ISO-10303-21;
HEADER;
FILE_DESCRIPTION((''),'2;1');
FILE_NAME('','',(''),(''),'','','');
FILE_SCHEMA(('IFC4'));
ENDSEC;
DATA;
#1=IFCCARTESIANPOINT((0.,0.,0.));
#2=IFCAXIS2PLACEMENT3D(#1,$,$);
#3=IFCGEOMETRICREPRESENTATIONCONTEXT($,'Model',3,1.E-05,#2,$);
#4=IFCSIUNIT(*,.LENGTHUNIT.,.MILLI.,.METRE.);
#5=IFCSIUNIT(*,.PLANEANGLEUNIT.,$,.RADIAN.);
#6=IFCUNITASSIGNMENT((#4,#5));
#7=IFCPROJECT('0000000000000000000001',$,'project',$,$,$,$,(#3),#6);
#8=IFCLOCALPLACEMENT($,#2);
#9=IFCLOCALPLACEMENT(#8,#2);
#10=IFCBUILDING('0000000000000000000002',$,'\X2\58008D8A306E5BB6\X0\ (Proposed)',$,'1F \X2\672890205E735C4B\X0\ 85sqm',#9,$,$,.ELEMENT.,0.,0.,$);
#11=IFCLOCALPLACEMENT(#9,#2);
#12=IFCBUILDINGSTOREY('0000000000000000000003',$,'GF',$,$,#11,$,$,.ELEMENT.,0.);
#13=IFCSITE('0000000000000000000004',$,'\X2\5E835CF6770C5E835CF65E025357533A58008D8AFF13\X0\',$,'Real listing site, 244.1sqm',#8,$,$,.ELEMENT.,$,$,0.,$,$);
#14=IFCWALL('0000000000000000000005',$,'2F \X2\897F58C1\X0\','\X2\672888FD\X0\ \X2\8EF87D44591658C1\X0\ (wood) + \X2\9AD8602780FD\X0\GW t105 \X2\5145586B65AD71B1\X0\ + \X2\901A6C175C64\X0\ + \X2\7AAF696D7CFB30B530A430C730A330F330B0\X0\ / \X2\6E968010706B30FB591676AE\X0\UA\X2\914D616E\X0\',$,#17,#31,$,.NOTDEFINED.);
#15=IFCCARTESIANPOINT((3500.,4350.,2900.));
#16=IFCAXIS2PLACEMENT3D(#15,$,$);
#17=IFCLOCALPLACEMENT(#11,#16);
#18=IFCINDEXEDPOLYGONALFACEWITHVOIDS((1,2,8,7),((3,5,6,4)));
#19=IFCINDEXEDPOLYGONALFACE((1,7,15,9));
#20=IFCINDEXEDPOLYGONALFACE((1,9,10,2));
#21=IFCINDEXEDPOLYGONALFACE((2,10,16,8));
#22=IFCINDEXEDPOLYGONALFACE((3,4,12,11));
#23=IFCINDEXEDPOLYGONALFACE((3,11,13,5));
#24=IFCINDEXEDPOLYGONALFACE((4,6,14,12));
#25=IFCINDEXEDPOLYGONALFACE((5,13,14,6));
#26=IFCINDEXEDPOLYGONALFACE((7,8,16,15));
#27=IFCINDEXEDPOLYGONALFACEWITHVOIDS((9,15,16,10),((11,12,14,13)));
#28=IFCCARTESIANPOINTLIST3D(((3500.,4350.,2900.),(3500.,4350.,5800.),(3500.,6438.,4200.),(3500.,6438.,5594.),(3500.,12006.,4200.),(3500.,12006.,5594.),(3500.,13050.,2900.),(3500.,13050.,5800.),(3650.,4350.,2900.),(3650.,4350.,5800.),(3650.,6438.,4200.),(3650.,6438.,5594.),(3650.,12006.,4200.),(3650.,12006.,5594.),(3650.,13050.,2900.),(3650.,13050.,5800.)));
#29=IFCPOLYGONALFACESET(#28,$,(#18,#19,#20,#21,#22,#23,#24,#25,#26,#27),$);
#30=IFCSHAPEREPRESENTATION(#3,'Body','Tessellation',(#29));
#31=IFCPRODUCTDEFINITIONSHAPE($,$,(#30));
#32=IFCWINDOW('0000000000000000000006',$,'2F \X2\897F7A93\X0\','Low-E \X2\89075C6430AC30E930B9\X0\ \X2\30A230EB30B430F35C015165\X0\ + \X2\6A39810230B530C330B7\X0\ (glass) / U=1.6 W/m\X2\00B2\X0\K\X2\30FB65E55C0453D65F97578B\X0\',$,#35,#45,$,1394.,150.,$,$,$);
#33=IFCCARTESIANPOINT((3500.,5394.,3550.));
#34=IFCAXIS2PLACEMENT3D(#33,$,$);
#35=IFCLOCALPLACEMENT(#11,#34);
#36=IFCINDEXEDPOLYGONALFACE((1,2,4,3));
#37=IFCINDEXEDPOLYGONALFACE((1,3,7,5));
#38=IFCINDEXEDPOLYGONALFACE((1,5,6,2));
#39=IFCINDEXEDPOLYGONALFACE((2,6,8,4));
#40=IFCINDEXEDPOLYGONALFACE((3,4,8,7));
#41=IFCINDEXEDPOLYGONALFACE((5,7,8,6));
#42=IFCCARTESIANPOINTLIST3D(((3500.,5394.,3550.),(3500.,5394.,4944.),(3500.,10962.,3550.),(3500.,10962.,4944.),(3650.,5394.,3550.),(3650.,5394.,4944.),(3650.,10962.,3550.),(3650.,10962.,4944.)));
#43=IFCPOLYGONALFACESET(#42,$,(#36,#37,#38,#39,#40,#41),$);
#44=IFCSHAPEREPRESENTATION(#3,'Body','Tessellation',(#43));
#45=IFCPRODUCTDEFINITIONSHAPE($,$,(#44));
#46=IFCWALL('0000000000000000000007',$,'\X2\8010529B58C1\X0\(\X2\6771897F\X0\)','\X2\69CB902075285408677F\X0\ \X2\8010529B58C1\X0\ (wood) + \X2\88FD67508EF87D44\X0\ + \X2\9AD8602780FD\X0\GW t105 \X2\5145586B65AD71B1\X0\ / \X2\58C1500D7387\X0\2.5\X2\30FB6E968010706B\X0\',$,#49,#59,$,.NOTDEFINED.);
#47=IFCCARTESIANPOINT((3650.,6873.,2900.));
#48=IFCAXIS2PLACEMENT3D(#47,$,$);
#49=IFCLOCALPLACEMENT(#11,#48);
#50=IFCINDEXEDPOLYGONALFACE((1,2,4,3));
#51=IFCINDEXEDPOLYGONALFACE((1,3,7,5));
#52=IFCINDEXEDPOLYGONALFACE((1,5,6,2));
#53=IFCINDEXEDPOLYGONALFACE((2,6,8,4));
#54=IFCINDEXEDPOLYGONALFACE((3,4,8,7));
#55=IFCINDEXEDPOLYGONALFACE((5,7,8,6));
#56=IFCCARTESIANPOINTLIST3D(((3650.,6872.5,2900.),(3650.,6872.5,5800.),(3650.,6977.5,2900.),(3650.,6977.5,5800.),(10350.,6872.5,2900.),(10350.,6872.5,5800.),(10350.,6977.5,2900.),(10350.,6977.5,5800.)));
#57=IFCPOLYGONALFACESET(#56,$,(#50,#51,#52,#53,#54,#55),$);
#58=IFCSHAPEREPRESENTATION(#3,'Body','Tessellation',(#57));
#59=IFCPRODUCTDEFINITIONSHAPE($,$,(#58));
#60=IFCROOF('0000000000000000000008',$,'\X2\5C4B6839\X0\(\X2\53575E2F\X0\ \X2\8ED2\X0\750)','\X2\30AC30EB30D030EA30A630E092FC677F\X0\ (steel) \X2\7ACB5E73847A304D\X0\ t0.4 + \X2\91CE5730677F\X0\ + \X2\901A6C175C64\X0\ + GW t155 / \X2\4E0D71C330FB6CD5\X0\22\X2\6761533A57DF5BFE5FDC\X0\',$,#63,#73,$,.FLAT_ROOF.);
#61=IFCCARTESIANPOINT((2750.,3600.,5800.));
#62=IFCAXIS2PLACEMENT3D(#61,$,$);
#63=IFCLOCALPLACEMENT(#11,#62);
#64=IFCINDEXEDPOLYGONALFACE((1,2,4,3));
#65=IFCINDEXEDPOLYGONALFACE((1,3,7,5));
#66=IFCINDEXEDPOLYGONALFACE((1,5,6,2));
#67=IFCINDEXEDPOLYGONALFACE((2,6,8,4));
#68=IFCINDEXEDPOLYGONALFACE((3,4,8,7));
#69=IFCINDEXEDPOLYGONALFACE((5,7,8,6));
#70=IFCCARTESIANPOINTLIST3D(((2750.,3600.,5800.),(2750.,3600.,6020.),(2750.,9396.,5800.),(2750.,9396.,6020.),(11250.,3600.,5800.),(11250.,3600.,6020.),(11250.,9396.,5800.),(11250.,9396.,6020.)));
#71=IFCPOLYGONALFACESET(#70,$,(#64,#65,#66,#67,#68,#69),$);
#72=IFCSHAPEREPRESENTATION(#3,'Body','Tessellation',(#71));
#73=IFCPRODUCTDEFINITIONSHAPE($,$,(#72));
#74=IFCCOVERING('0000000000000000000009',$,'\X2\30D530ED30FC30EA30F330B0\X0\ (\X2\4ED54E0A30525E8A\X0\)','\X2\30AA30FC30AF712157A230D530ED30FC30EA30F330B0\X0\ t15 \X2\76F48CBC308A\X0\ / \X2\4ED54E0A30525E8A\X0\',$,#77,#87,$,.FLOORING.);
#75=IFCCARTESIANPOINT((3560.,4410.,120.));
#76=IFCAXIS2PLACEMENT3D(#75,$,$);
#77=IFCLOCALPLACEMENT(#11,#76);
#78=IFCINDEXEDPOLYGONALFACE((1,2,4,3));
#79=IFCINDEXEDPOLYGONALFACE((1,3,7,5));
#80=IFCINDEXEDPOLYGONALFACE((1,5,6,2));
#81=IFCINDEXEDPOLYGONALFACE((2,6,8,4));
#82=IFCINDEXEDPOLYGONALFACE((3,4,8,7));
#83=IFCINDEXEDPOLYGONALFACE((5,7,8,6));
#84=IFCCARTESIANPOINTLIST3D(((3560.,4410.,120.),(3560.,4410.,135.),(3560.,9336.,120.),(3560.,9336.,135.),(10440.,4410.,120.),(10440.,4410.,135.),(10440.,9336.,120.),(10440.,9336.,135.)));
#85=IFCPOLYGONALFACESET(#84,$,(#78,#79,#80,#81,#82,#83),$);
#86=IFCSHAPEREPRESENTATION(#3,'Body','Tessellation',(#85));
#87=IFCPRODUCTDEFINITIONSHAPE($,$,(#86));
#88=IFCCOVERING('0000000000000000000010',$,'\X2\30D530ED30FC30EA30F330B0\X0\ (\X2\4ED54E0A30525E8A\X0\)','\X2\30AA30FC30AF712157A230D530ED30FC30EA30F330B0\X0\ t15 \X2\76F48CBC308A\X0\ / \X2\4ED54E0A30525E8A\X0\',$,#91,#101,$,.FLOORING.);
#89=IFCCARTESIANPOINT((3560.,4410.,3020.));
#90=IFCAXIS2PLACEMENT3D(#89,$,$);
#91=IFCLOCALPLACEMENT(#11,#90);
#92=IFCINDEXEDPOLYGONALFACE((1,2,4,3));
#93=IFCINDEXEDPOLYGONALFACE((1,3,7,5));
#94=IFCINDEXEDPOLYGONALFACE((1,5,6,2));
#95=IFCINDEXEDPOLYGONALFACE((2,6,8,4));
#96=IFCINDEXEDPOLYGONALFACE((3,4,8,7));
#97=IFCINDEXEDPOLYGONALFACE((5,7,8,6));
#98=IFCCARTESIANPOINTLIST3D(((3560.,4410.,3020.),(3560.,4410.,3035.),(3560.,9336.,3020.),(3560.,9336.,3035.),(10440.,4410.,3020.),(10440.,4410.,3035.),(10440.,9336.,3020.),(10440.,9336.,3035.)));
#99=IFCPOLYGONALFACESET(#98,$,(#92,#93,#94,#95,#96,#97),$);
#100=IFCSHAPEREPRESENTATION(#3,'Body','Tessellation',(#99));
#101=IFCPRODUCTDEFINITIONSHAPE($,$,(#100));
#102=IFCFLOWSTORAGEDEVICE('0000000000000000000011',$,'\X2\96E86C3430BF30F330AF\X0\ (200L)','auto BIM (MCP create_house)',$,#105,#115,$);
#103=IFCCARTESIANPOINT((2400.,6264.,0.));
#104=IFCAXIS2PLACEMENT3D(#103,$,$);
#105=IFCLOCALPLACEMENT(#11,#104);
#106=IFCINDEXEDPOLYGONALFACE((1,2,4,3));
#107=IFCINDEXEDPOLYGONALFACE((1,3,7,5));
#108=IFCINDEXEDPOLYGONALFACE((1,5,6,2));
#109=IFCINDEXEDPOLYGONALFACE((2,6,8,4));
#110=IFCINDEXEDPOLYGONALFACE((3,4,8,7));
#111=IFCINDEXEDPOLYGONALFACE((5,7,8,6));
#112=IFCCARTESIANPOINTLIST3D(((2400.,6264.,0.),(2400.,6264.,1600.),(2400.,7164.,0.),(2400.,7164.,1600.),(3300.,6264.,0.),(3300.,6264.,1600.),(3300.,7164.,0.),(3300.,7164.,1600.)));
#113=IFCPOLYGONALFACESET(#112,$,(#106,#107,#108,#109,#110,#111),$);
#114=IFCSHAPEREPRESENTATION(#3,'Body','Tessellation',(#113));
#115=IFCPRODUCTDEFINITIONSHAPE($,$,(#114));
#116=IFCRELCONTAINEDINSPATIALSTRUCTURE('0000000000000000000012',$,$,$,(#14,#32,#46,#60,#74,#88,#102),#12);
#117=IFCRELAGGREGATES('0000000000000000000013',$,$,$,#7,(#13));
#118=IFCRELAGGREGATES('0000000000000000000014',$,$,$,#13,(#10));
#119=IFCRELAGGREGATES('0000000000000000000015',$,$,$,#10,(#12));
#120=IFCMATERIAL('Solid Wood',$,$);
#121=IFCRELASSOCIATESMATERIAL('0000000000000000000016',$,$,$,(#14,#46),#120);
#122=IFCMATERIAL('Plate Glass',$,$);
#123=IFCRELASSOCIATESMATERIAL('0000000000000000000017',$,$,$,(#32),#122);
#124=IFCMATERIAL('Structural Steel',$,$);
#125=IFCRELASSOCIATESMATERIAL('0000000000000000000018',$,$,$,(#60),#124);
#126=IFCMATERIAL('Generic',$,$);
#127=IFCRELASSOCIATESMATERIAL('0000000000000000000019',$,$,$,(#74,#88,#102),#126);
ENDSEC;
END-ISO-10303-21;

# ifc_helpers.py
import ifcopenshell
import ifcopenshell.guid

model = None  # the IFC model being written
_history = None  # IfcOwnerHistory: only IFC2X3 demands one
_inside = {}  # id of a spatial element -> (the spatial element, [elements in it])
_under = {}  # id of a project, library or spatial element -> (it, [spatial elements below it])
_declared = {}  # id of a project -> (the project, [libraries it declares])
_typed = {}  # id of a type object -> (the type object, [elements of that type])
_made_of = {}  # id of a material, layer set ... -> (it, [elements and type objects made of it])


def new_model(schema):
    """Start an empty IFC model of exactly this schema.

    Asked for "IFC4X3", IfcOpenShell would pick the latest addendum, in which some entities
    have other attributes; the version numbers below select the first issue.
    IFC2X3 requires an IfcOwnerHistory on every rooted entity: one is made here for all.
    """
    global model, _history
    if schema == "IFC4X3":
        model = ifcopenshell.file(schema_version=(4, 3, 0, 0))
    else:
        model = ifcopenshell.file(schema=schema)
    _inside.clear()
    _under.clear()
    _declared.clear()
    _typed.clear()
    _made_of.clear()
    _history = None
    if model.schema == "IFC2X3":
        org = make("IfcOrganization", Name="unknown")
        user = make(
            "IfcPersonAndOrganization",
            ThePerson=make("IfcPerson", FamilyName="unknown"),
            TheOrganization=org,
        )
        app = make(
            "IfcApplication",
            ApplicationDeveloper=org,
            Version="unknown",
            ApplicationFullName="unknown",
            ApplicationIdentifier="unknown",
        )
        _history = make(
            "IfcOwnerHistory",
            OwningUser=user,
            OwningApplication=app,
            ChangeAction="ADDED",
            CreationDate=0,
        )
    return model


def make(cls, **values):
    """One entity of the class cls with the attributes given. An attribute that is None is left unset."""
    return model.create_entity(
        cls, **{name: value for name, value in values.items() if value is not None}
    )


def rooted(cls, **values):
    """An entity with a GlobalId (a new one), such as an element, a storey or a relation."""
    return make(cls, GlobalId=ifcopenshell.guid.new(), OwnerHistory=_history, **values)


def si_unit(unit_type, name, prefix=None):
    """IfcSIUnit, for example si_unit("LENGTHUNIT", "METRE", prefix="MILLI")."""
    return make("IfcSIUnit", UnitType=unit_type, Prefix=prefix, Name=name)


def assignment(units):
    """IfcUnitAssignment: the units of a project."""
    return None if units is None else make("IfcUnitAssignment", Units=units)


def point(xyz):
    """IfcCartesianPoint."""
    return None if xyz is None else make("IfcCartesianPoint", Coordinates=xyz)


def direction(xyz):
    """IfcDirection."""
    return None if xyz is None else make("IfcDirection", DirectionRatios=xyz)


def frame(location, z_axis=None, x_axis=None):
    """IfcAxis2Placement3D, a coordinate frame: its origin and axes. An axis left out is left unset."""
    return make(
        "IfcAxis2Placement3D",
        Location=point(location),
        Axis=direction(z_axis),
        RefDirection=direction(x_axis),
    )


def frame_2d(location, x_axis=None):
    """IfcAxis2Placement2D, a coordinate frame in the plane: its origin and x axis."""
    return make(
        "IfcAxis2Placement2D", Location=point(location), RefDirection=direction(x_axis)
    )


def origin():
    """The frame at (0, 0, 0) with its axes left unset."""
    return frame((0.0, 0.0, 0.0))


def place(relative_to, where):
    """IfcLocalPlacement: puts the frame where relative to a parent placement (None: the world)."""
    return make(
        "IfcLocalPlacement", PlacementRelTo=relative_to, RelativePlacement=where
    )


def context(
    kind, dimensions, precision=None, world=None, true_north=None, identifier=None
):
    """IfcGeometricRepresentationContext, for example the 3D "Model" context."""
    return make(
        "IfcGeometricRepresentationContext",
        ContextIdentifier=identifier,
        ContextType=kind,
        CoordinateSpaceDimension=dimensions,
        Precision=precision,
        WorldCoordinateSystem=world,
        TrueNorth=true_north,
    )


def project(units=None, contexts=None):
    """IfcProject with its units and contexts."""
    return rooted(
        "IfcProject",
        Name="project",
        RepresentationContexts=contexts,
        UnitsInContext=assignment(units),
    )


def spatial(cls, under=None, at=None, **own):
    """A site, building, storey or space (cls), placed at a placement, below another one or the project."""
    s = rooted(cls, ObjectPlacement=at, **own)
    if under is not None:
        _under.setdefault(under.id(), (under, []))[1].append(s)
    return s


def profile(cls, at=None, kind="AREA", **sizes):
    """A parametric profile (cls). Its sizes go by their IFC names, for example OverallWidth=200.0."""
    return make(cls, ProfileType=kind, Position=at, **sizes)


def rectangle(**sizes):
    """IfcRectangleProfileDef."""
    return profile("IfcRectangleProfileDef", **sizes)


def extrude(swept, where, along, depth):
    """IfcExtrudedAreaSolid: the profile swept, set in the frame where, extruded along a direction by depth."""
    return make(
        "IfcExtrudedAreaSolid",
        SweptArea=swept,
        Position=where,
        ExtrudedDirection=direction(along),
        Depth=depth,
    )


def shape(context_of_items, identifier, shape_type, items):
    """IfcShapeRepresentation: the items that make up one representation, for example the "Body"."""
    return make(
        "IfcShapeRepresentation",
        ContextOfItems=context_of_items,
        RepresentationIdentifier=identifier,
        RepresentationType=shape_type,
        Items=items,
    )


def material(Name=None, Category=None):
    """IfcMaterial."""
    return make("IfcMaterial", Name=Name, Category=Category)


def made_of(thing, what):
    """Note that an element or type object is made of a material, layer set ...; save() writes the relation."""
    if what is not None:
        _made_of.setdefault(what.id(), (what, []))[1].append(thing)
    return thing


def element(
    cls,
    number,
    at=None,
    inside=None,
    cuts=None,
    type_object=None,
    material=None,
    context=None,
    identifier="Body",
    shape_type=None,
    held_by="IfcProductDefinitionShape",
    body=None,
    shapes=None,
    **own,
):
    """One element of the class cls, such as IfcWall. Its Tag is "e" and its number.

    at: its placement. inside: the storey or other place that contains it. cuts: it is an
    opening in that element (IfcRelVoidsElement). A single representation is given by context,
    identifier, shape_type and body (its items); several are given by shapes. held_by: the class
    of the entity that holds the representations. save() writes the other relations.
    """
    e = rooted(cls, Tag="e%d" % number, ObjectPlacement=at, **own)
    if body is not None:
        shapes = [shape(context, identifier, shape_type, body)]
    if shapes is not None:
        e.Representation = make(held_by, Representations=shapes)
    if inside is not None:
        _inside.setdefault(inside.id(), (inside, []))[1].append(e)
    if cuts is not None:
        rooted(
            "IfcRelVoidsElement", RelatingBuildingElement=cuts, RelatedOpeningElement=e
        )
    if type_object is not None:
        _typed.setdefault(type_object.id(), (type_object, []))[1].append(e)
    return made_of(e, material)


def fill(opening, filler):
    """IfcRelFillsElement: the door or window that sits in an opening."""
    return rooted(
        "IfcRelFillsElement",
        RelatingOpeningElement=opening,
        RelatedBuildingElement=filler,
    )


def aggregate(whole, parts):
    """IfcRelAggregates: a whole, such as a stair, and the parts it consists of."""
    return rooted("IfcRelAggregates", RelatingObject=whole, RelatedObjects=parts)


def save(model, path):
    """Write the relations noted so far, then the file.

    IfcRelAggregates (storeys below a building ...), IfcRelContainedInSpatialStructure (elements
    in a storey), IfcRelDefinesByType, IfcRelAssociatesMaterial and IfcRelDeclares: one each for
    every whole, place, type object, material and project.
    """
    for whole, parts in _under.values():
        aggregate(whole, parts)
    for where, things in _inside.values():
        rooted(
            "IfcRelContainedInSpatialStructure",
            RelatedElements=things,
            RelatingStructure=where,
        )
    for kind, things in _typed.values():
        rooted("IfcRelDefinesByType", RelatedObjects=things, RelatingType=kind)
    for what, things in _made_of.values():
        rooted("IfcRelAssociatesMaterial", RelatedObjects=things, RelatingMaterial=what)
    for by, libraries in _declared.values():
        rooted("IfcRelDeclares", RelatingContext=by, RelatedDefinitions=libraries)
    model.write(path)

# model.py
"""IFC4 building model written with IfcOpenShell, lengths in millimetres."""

from ifc_helpers import new_model, si_unit, frame, frame_2d, origin, place, context, project, spatial, rectangle, extrude, material, element, fill, save


model = new_model("IFC4")

# Units and contexts
model_context = context("Model", 3, precision=1e-05, world=origin())
ifc_project = project(units=[si_unit("LENGTHUNIT", "METRE", prefix="MILLI"), si_unit("PLANEANGLEUNIT", "RADIAN")], contexts=[model_context])

# Site, building, storey
site_placement = place(None, origin())
site = spatial("IfcSite", under=ifc_project, at=site_placement, Name="広島県広島市南区堀越３", ObjectType="Real listing site, 244.1sqm", CompositionType="ELEMENT", RefElevation=0.0)
building_placement = place(site_placement, origin())
building = spatial("IfcBuilding", under=site, at=building_placement, Name="堀越の家 (Proposed)", ObjectType="1F 木造平屋 85sqm", CompositionType="ELEMENT", ElevationOfRefHeight=0.0, ElevationOfTerrain=0.0)
storey_placement = place(building_placement, origin())
storey = spatial("IfcBuildingStorey", under=building, at=storey_placement, Name="GF", CompositionType="ELEMENT", Elevation=0.0)

# Shared definitions
ifc_material_1 = material(Name="Solid Wood")
ifc_material_2 = material(Name="Generic")

# Shared definitions
ifc_material_3 = material(Name="Plate Glass")

# Wall, opening, window
wall_1_placement = place(storey_placement, frame((3500.0, 4350.0, 2900.0)))
wall_1 = element("IfcWall", 1, at=wall_1_placement, inside=storey, material=ifc_material_1, Name="2F 西壁", Description="木製 軸組外壁 (wood) + 高性能GW t105 充填断熱 + 通気層 + 窯業系サイディング / 準耐火・外皮UA配慮", PredefinedType="NOTDEFINED", context=model_context, shape_type="SweptSolid", body=[
    extrude(rectangle(XDim=150.0, YDim=8700.0, at=frame_2d((75.0, 4350.0))), frame((3500.0, 4350.0, 2900.0)), (0.0, 0.0, 1.0), 2900.0),
])
opening_1_placement = place(storey_placement, frame((3500.0, 5394.0, 3550.0)))
opening_1 = element("IfcOpeningElement", 2, at=opening_1_placement, cuts=wall_1, PredefinedType="NOTDEFINED", context=model_context, shape_type="SweptSolid", body=[
    extrude(rectangle(XDim=150.0, YDim=5568.0, at=frame_2d((75.0, 2784.0))), frame((3500.0, 5394.0, 3550.0)), (0.0, 0.0, 1.0), 1394.0),
])
window_1_placement = place(storey_placement, frame((3500.0, 5394.0, 3550.0)))
window_1 = element("IfcWindow", 3, at=window_1_placement, inside=storey, material=ifc_material_3, Name="2F 西窓", Description="Low-E 複層ガラス アルゴン封入 + 樹脂サッシ (glass) / U=1.6 W/m²K・日射取得型", OverallHeight=1394.0, OverallWidth=150.0, context=model_context, shape_type="SweptSolid", body=[
    extrude(rectangle(XDim=150.0, YDim=5568.0, at=frame_2d((75.0, 2784.0))), frame((3500.0, 5394.0, 3550.0)), (0.0, 0.0, 1.0), 1394.0),
])
fill(opening_1, window_1)

# Wall
wall_2_placement = place(storey_placement, frame((3650.0, 6873.0, 2900.0)))
element("IfcWall", 4, at=wall_2_placement, inside=storey, material=ifc_material_1, Name="耐力壁(東西)", Description="構造用合板 耐力壁 (wood) + 製材軸組 + 高性能GW t105 充填断熱 / 壁倍率2.5・準耐火", PredefinedType="NOTDEFINED", context=model_context, shape_type="SweptSolid", body=[
    extrude(rectangle(XDim=6700.0, YDim=105.0, at=frame_2d((3350.0, 52.0))), frame((3650.0, 6873.0, 2900.0)), (0.0, 0.0, 1.0), 2900.0),
])

# Roof
ifc_material_4 = material(Name="Structural Steel")
for number, where, name in (
    (5, (2750.0, 3600.0, 5800.0), "屋根(南帯 軒750)"),
):
    element("IfcRoof", number, at=place(storey_placement, frame(where)), inside=storey, material=ifc_material_4, Name=name, Description="ガルバリウム鋼板 (steel) 立平葺き t0.4 + 野地板 + 通気層 + GW t155 / 不燃・法22条区域対応", PredefinedType="FLAT_ROOF", context=model_context, shape_type="SweptSolid", body=[
        extrude(rectangle(XDim=8500.0, YDim=5796.0, at=frame_2d((4250.0, 2898.0))), frame((2750.0, 3600.0, 5800.0)), (0.0, 0.0, 1.0), 220.0),
    ])

# Coverings
covering_1_placement = place(storey_placement, frame((3560.0, 4410.0, 120.0)))
element("IfcCovering", 6, at=covering_1_placement, inside=storey, material=ifc_material_2, Name="フローリング (仕上げ床)", Description="オーク無垢フローリング t15 直貼り / 仕上げ床", PredefinedType="FLOORING", context=model_context, shape_type="SweptSolid", body=[
    extrude(rectangle(XDim=6880.0, YDim=4926.0, at=frame_2d((3440.0, 2463.0))), frame((3560.0, 4410.0, 120.0)), (0.0, 0.0, 1.0), 15.0),
])
covering_2_placement = place(storey_placement, frame((3560.0, 4410.0, 3020.0)))
element("IfcCovering", 7, at=covering_2_placement, inside=storey, material=ifc_material_2, Name="フローリング (仕上げ床)", Description="オーク無垢フローリング t15 直貼り / 仕上げ床", PredefinedType="FLOORING", context=model_context, shape_type="SweptSolid", body=[
    extrude(rectangle(XDim=6880.0, YDim=4926.0, at=frame_2d((3440.0, 2463.0))), frame((3560.0, 4410.0, 3020.0)), (0.0, 0.0, 1.0), 15.0),
])

# Flow storage device
flow_storage_device_placement = place(storey_placement, frame((2400.0, 6264.0, 0.0)))
element("IfcFlowStorageDevice", 8, at=flow_storage_device_placement, inside=storey, material=ifc_material_2, Name="雨水タンク (200L)", Description="auto BIM (MCP create_house)", context=model_context, shape_type="SweptSolid", body=[
    extrude(rectangle(XDim=900.0, YDim=900.0, at=frame_2d((450.0, 450.0))), frame((2400.0, 6264.0, 0.0)), (0.0, 0.0, 1.0), 1600.0),
])

save(model, "model.ifc")
